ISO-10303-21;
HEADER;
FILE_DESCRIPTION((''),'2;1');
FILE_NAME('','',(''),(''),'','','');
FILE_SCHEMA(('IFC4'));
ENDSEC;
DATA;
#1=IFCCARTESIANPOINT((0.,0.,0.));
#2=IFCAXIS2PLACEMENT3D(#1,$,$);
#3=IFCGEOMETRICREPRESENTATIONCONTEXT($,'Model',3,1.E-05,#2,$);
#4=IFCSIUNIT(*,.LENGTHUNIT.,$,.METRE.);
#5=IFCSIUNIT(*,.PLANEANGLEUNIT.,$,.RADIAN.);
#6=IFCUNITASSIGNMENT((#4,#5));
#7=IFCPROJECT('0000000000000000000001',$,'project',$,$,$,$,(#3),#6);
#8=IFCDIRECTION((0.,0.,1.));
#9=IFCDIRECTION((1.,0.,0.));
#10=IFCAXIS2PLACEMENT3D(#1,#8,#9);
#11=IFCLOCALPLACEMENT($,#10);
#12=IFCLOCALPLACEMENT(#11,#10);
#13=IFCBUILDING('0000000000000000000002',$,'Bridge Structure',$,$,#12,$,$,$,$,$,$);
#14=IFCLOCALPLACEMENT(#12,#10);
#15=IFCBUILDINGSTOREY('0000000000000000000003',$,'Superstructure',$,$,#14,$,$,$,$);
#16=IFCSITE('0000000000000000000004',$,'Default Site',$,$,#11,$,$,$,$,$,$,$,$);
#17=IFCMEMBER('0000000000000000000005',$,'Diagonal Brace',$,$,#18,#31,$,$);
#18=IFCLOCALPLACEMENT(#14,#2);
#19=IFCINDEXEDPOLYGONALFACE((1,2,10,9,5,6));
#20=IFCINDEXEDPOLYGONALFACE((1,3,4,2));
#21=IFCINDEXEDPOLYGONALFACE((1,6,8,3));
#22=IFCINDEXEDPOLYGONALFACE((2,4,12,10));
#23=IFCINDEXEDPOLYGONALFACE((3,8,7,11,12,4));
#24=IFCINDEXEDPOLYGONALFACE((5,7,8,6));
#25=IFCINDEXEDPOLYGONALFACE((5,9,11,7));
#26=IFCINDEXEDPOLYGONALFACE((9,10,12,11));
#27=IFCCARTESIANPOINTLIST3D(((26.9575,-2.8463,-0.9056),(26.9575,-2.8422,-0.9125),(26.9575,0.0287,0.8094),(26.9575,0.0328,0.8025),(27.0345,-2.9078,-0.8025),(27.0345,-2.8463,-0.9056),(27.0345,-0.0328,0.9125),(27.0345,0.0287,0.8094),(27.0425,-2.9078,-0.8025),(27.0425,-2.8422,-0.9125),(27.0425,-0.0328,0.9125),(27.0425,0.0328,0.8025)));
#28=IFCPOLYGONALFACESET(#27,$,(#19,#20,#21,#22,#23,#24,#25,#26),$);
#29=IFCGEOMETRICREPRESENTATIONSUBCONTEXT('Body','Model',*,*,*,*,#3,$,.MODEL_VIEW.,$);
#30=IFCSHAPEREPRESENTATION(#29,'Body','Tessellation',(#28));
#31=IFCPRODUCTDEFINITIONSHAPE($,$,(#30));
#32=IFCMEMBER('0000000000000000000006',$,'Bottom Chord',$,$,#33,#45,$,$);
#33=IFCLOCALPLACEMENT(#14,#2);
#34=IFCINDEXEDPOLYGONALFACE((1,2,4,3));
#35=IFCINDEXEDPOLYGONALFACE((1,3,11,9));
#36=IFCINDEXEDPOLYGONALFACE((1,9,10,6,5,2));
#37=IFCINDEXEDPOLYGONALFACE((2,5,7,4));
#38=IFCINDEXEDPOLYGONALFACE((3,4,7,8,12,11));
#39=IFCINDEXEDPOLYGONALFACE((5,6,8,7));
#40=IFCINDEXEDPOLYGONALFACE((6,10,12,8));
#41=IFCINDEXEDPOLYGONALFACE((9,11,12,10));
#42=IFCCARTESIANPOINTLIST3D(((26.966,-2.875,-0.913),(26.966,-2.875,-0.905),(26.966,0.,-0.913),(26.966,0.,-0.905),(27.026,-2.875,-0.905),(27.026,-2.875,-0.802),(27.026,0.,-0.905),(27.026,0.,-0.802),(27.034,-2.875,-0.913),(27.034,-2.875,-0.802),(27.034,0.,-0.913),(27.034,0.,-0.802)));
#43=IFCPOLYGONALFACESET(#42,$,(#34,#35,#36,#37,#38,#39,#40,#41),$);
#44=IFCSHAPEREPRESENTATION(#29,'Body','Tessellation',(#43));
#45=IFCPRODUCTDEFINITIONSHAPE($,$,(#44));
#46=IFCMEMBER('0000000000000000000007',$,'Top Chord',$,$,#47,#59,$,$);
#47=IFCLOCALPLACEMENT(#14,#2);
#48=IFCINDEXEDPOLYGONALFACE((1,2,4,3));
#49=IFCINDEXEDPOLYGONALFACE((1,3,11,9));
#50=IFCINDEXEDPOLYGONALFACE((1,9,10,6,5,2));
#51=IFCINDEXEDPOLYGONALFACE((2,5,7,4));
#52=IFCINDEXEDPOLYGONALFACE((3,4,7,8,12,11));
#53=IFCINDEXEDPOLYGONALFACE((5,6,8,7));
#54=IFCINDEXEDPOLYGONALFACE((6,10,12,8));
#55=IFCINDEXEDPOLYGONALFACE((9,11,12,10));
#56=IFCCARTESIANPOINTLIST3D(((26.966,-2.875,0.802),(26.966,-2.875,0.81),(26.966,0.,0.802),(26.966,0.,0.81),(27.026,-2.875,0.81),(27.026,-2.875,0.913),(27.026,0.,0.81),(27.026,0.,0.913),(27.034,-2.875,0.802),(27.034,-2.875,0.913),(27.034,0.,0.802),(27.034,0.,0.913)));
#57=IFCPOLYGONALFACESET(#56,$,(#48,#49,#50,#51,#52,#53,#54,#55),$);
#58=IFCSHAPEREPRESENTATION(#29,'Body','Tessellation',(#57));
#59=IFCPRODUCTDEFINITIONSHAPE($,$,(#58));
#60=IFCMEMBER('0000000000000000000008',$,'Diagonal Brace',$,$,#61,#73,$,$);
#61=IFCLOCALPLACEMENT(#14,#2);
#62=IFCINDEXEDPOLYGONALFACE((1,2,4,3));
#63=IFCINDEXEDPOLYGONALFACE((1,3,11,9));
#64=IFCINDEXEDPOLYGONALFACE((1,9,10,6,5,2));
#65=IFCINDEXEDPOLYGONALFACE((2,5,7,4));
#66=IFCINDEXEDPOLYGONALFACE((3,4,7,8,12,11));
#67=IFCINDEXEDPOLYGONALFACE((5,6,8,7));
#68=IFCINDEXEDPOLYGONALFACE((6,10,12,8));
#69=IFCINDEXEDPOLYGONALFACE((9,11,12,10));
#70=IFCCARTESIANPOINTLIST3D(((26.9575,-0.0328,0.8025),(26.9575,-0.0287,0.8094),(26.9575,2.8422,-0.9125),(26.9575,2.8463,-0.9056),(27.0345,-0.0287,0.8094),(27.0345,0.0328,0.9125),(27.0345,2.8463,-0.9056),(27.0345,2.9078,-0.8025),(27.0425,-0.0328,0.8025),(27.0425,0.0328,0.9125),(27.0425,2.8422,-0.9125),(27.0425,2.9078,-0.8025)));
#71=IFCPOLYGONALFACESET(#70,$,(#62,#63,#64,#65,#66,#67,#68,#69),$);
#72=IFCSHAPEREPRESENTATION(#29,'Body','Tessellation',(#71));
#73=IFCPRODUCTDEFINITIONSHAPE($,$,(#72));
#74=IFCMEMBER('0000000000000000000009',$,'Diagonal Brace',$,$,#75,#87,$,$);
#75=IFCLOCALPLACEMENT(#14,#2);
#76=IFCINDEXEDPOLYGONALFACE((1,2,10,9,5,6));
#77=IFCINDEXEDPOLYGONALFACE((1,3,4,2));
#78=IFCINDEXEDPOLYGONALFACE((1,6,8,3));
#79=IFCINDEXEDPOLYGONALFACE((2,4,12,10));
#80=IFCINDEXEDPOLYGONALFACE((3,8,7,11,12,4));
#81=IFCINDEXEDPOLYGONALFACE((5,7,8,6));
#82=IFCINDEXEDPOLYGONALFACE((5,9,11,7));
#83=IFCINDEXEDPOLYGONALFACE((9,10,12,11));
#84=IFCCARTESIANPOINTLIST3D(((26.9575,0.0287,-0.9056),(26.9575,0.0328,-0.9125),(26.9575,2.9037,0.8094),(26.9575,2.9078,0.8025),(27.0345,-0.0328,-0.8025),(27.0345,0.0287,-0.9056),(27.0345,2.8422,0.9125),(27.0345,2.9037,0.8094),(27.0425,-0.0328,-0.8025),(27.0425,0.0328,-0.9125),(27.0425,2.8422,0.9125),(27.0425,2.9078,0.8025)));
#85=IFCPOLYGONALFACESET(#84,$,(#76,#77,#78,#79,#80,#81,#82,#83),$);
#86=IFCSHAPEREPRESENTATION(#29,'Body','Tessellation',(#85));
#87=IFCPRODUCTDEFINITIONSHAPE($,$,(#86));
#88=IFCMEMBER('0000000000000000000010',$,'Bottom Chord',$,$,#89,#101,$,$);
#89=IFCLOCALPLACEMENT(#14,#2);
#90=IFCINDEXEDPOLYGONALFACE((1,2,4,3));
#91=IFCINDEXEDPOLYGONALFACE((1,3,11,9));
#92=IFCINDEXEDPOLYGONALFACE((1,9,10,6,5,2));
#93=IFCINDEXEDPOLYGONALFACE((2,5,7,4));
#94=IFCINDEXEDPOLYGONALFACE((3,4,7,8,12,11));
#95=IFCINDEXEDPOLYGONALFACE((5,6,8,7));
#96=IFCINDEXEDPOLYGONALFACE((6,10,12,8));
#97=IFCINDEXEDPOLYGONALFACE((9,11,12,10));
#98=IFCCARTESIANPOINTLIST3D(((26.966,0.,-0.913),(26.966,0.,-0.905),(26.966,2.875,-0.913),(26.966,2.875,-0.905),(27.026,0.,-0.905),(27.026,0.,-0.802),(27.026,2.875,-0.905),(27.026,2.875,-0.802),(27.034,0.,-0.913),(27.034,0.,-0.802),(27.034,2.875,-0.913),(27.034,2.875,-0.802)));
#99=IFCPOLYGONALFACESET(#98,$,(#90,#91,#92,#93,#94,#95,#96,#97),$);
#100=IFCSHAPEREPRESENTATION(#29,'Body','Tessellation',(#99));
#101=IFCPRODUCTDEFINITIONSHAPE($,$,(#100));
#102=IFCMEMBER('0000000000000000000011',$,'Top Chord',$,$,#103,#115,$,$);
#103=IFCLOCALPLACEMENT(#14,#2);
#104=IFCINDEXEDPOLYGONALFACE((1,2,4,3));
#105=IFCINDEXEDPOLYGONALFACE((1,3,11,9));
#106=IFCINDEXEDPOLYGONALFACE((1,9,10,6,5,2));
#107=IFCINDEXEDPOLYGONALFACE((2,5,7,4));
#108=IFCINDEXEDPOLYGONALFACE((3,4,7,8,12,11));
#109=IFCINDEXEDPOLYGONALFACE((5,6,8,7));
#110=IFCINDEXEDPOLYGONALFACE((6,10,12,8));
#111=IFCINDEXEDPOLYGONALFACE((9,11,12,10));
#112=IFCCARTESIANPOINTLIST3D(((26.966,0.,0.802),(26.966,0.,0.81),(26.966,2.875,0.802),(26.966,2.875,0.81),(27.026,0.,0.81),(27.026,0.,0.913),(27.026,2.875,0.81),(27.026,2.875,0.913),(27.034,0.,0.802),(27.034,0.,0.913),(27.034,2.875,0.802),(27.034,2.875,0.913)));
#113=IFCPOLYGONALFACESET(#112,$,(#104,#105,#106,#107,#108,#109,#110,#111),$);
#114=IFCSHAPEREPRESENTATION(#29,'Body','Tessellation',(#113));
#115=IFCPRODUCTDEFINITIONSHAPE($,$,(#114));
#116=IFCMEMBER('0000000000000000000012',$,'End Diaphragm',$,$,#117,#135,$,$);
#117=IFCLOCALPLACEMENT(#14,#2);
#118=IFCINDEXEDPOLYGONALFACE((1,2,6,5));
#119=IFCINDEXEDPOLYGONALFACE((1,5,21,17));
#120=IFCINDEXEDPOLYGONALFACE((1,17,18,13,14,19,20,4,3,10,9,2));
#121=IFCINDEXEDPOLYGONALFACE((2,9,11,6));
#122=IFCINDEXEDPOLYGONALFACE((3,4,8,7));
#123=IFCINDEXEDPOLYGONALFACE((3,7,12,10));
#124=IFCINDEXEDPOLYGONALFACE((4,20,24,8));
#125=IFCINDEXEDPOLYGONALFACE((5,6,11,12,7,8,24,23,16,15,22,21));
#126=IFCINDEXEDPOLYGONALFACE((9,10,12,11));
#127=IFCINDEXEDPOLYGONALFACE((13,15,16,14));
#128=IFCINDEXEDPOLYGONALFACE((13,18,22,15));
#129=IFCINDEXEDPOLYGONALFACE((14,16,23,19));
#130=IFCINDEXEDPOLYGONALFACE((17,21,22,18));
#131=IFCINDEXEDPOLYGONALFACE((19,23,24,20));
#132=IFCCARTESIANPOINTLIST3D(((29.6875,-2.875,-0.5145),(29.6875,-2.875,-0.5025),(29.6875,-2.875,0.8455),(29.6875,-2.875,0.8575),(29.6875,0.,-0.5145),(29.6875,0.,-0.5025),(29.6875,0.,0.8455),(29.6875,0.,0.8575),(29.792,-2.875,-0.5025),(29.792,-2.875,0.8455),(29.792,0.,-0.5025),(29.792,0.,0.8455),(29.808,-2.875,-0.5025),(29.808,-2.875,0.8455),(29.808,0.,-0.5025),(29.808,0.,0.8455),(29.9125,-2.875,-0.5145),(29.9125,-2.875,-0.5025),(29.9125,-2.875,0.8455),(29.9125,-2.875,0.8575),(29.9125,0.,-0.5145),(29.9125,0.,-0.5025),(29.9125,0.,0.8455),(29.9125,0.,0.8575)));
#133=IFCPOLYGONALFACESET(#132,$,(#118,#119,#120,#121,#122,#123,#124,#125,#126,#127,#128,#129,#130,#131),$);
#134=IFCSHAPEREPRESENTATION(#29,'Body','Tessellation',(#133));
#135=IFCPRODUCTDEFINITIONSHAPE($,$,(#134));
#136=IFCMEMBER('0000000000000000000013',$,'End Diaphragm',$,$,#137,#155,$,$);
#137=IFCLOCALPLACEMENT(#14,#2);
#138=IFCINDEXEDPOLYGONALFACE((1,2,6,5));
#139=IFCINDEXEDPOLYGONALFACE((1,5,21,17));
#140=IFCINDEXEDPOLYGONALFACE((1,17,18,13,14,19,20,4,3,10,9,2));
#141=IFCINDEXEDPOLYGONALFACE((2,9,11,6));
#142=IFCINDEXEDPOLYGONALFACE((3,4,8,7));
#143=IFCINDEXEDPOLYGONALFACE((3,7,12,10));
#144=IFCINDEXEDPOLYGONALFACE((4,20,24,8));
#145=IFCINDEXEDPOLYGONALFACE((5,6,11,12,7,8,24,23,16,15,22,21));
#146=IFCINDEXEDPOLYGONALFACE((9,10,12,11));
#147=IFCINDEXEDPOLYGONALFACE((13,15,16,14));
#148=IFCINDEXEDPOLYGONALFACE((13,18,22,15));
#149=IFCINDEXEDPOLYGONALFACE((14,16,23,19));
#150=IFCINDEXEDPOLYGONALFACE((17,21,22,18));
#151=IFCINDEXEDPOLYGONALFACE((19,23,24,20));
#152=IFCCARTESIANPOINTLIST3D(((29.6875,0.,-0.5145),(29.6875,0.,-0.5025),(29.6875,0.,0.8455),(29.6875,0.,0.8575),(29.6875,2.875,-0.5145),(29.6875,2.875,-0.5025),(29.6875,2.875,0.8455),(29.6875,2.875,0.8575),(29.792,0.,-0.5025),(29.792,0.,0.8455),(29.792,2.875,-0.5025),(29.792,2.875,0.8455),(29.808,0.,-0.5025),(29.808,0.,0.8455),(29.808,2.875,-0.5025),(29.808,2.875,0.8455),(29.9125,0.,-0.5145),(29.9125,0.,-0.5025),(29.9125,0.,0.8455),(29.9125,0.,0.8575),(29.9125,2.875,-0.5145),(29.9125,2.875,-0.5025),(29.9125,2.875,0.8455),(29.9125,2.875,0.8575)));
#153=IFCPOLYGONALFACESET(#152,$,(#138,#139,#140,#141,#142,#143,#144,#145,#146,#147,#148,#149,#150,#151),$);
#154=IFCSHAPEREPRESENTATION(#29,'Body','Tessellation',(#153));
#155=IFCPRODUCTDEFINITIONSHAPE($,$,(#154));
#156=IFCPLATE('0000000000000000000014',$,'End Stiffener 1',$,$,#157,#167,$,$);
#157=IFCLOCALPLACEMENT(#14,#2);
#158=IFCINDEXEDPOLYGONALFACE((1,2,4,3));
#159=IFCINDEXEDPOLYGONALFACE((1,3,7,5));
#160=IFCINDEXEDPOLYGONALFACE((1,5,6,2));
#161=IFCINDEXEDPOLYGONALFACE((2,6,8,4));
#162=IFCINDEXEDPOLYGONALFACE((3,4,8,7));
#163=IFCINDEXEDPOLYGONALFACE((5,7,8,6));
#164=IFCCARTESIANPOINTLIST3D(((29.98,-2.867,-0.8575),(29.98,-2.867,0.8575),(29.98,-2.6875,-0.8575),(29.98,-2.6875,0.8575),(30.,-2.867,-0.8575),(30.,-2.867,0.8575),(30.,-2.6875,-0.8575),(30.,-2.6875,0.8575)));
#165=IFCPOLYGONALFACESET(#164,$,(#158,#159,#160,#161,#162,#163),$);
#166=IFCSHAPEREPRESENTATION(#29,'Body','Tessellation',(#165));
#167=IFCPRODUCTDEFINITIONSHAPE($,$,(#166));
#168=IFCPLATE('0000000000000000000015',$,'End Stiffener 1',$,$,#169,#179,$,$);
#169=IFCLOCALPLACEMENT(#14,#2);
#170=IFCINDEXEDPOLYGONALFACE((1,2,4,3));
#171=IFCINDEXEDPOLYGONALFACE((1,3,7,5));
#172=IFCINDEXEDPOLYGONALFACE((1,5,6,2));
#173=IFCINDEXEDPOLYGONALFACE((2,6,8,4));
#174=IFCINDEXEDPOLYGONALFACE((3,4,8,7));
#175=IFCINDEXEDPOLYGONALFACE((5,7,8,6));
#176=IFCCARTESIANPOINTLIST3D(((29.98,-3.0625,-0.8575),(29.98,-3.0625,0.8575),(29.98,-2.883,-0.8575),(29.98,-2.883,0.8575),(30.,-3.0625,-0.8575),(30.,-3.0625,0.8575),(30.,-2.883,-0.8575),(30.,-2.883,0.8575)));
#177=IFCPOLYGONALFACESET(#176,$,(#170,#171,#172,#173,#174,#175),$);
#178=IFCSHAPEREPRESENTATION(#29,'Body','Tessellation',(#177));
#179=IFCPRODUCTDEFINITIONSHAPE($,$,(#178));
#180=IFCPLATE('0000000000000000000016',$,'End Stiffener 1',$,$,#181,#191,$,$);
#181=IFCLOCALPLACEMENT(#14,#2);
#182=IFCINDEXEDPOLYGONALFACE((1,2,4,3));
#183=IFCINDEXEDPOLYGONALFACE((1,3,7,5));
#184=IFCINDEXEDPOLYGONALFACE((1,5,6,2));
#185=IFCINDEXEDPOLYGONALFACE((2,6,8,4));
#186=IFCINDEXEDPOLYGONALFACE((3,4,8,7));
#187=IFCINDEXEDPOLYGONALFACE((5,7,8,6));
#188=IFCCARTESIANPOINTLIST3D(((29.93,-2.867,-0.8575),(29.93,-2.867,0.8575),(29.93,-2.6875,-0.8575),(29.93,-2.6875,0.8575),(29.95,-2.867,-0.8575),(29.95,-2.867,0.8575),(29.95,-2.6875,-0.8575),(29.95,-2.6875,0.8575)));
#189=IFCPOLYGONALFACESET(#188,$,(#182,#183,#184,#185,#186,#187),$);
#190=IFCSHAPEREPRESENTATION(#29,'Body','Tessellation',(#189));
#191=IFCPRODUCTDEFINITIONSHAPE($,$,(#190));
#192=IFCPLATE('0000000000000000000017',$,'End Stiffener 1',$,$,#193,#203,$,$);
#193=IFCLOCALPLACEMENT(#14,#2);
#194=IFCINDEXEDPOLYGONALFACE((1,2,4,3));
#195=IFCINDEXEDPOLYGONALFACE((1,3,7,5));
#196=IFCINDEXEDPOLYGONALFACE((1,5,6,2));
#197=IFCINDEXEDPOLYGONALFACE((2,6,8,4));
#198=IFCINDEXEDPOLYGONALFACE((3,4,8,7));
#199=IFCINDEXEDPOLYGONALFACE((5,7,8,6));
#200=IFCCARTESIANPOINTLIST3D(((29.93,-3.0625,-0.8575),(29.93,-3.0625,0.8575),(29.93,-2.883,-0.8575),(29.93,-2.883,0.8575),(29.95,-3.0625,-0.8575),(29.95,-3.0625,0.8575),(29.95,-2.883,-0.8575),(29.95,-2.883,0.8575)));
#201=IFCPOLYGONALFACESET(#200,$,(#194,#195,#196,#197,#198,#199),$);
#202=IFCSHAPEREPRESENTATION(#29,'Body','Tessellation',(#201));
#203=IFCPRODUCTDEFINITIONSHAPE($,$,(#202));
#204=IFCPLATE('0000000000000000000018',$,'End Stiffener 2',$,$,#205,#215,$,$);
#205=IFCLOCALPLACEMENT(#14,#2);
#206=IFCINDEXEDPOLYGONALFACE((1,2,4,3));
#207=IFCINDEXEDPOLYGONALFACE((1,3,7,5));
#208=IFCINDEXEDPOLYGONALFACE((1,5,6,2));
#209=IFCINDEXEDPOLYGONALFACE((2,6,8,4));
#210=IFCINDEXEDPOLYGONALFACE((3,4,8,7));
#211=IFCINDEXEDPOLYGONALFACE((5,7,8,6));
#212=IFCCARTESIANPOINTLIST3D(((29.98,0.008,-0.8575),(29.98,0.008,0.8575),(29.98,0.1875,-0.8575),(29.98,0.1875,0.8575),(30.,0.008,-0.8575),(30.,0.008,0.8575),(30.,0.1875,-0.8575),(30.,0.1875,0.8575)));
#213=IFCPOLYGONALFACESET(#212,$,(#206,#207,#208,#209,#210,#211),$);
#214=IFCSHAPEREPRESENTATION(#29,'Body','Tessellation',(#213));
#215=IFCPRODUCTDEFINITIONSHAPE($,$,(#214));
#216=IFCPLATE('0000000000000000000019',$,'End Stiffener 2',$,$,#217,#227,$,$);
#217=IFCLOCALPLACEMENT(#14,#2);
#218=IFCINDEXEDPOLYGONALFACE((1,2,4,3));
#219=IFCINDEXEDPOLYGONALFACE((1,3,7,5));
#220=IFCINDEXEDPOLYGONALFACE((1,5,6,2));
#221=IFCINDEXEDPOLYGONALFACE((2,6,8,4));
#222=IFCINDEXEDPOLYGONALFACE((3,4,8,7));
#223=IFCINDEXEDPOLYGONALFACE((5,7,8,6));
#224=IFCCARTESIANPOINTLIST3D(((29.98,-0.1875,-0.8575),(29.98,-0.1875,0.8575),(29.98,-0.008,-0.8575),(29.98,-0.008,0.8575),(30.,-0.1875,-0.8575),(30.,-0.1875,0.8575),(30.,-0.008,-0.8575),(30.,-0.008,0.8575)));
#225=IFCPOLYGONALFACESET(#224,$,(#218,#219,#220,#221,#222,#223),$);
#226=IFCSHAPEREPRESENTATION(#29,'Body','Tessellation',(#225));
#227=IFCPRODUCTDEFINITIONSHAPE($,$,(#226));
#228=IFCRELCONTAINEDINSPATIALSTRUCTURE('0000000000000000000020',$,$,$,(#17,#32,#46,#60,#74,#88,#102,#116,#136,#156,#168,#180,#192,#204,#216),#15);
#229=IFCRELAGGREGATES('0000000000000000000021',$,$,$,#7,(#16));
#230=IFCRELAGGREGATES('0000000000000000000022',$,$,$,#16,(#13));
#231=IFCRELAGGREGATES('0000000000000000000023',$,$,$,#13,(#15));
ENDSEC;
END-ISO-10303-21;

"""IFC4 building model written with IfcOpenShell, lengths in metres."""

from ifc_helpers import new_model, si_unit, frame, origin, origin_with_axes, origin_2d_with_axis, place, context, subcontext, project, spatial, rectangle, i_section, l_section, extrude, element, save


model = new_model("IFC4")

# Units and contexts
model_context = context("Model", 3, precision=1e-05, world=origin())
body_context = subcontext(model_context, "Body", "Model", "MODEL_VIEW")
ifc_project = project(units=[si_unit("LENGTHUNIT", "METRE"), si_unit("PLANEANGLEUNIT", "RADIAN")], contexts=[model_context])

# Site, building, storey
site_placement = place(None, origin_with_axes())
site = spatial("IfcSite", under=ifc_project, at=site_placement, Name="Default Site")
building_placement = place(site_placement, origin_with_axes())
building = spatial("IfcBuilding", under=site, at=building_placement, Name="Bridge Structure")
storey_placement = place(building_placement, origin_with_axes())
storey = spatial("IfcBuildingStorey", under=building, at=storey_placement, Name="Superstructure")

# Members
member_placement = place(storey_placement, frame((27.0, -2.875, -0.8575), z_axis=(0.0, 0.858808, 0.512298), x_axis=(-1.0, 0.0, 0.0)))
element("IfcMember", 1, at=member_placement, inside=storey, Name="Diagonal Brace", context=body_context, shape_type="SweptSolid", body=[
    extrude(l_section(Depth=0.128, Width=0.085, Thickness=0.008, at=origin_2d_with_axis()), origin_with_axes(), (0.0, 0.0, 1.0), 3.3477),
])
for number, where, z_axis, x_axis, name in (
    (2, (27.0, -2.875, -0.8575), (0.0, 1.0, 0.0), (-1.0, 0.0, 0.0), "Bottom Chord"),
    (3, (27.0, -2.875, 0.8575), (0.0, 1.0, 0.0), (-1.0, 0.0, 0.0), "Top Chord"),
):
    element("IfcMember", number, at=place(storey_placement, frame(where, z_axis=z_axis, x_axis=x_axis)), inside=storey, Name=name, context=body_context, shape_type="SweptSolid", body=[
        extrude(l_section(Depth=0.111, Width=0.068, Thickness=0.008, at=origin_2d_with_axis()), origin_with_axes(), (0.0, 0.0, 1.0), 2.875),
    ])
for number, where, z_axis, x_axis, name in (
    (4, (27.0, 0.0, 0.8575), (0.0, 0.858808, -0.512298), (-1.0, 0.0, 0.0), "Diagonal Brace"),
    (5, (27.0, 0.0, -0.8575), (0.0, 0.858808, 0.512298), (-1.0, 0.0, 0.0), "Diagonal Brace"),
):
    element("IfcMember", number, at=place(storey_placement, frame(where, z_axis=z_axis, x_axis=x_axis)), inside=storey, Name=name, context=body_context, shape_type="SweptSolid", body=[
        extrude(l_section(Depth=0.128, Width=0.085, Thickness=0.008, at=origin_2d_with_axis()), origin_with_axes(), (0.0, 0.0, 1.0), 3.3477),
    ])
for number, where, z_axis, x_axis, name in (
    (6, (27.0, 0.0, -0.8575), (0.0, 1.0, 0.0), (-1.0, 0.0, 0.0), "Bottom Chord"),
    (7, (27.0, 0.0, 0.8575), (0.0, 1.0, 0.0), (-1.0, 0.0, 0.0), "Top Chord"),
):
    element("IfcMember", number, at=place(storey_placement, frame(where, z_axis=z_axis, x_axis=x_axis)), inside=storey, Name=name, context=body_context, shape_type="SweptSolid", body=[
        extrude(l_section(Depth=0.111, Width=0.068, Thickness=0.008, at=origin_2d_with_axis()), origin_with_axes(), (0.0, 0.0, 1.0), 2.875),
    ])
for number, where, z_axis, x_axis, name in (
    (8, (29.8, -2.875, 0.1715), (0.0, 1.0, 0.0), (-1.0, 0.0, 0.0), "End Diaphragm"),
    (9, (29.8, 0.0, 0.1715), (0.0, 1.0, 0.0), (-1.0, 0.0, 0.0), "End Diaphragm"),
):
    element("IfcMember", number, at=place(storey_placement, frame(where, z_axis=z_axis, x_axis=x_axis)), inside=storey, Name=name, context=body_context, shape_type="SweptSolid", body=[
        extrude(i_section(OverallWidth=0.225, OverallDepth=1.372, WebThickness=0.016, FlangeThickness=0.012, at=origin_2d_with_axis()), origin_with_axes(), (0.0, 0.0, 1.0), 2.875),
    ])

# Plates
for number, where, z_axis, x_axis, name in (
    (10, (29.99, -2.7772, -0.8575), (0.0, 0.0, 1.0), (1.0, 0.0, 0.0), "End Stiffener 1"),
    (11, (29.99, -2.9728, -0.8575), (0.0, 0.0, 1.0), (1.0, 0.0, 0.0), "End Stiffener 1"),
    (12, (29.94, -2.7772, -0.8575), (0.0, 0.0, 1.0), (1.0, 0.0, 0.0), "End Stiffener 1"),
    (13, (29.94, -2.9728, -0.8575), (0.0, 0.0, 1.0), (1.0, 0.0, 0.0), "End Stiffener 1"),
    (14, (29.99, 0.0978, -0.8575), (0.0, 0.0, 1.0), (1.0, 0.0, 0.0), "End Stiffener 2"),
    (15, (29.99, -0.0978, -0.8575), (0.0, 0.0, 1.0), (1.0, 0.0, 0.0), "End Stiffener 2"),
):
    element("IfcPlate", number, at=place(storey_placement, frame(where, z_axis=z_axis, x_axis=x_axis)), inside=storey, Name=name, context=body_context, shape_type="SweptSolid", body=[
        extrude(rectangle(XDim=0.02, YDim=0.1795, at=origin_2d_with_axis()), origin_with_axes(), (0.0, 0.0, 1.0), 1.715),
    ])

save(model, "model.ifc")
